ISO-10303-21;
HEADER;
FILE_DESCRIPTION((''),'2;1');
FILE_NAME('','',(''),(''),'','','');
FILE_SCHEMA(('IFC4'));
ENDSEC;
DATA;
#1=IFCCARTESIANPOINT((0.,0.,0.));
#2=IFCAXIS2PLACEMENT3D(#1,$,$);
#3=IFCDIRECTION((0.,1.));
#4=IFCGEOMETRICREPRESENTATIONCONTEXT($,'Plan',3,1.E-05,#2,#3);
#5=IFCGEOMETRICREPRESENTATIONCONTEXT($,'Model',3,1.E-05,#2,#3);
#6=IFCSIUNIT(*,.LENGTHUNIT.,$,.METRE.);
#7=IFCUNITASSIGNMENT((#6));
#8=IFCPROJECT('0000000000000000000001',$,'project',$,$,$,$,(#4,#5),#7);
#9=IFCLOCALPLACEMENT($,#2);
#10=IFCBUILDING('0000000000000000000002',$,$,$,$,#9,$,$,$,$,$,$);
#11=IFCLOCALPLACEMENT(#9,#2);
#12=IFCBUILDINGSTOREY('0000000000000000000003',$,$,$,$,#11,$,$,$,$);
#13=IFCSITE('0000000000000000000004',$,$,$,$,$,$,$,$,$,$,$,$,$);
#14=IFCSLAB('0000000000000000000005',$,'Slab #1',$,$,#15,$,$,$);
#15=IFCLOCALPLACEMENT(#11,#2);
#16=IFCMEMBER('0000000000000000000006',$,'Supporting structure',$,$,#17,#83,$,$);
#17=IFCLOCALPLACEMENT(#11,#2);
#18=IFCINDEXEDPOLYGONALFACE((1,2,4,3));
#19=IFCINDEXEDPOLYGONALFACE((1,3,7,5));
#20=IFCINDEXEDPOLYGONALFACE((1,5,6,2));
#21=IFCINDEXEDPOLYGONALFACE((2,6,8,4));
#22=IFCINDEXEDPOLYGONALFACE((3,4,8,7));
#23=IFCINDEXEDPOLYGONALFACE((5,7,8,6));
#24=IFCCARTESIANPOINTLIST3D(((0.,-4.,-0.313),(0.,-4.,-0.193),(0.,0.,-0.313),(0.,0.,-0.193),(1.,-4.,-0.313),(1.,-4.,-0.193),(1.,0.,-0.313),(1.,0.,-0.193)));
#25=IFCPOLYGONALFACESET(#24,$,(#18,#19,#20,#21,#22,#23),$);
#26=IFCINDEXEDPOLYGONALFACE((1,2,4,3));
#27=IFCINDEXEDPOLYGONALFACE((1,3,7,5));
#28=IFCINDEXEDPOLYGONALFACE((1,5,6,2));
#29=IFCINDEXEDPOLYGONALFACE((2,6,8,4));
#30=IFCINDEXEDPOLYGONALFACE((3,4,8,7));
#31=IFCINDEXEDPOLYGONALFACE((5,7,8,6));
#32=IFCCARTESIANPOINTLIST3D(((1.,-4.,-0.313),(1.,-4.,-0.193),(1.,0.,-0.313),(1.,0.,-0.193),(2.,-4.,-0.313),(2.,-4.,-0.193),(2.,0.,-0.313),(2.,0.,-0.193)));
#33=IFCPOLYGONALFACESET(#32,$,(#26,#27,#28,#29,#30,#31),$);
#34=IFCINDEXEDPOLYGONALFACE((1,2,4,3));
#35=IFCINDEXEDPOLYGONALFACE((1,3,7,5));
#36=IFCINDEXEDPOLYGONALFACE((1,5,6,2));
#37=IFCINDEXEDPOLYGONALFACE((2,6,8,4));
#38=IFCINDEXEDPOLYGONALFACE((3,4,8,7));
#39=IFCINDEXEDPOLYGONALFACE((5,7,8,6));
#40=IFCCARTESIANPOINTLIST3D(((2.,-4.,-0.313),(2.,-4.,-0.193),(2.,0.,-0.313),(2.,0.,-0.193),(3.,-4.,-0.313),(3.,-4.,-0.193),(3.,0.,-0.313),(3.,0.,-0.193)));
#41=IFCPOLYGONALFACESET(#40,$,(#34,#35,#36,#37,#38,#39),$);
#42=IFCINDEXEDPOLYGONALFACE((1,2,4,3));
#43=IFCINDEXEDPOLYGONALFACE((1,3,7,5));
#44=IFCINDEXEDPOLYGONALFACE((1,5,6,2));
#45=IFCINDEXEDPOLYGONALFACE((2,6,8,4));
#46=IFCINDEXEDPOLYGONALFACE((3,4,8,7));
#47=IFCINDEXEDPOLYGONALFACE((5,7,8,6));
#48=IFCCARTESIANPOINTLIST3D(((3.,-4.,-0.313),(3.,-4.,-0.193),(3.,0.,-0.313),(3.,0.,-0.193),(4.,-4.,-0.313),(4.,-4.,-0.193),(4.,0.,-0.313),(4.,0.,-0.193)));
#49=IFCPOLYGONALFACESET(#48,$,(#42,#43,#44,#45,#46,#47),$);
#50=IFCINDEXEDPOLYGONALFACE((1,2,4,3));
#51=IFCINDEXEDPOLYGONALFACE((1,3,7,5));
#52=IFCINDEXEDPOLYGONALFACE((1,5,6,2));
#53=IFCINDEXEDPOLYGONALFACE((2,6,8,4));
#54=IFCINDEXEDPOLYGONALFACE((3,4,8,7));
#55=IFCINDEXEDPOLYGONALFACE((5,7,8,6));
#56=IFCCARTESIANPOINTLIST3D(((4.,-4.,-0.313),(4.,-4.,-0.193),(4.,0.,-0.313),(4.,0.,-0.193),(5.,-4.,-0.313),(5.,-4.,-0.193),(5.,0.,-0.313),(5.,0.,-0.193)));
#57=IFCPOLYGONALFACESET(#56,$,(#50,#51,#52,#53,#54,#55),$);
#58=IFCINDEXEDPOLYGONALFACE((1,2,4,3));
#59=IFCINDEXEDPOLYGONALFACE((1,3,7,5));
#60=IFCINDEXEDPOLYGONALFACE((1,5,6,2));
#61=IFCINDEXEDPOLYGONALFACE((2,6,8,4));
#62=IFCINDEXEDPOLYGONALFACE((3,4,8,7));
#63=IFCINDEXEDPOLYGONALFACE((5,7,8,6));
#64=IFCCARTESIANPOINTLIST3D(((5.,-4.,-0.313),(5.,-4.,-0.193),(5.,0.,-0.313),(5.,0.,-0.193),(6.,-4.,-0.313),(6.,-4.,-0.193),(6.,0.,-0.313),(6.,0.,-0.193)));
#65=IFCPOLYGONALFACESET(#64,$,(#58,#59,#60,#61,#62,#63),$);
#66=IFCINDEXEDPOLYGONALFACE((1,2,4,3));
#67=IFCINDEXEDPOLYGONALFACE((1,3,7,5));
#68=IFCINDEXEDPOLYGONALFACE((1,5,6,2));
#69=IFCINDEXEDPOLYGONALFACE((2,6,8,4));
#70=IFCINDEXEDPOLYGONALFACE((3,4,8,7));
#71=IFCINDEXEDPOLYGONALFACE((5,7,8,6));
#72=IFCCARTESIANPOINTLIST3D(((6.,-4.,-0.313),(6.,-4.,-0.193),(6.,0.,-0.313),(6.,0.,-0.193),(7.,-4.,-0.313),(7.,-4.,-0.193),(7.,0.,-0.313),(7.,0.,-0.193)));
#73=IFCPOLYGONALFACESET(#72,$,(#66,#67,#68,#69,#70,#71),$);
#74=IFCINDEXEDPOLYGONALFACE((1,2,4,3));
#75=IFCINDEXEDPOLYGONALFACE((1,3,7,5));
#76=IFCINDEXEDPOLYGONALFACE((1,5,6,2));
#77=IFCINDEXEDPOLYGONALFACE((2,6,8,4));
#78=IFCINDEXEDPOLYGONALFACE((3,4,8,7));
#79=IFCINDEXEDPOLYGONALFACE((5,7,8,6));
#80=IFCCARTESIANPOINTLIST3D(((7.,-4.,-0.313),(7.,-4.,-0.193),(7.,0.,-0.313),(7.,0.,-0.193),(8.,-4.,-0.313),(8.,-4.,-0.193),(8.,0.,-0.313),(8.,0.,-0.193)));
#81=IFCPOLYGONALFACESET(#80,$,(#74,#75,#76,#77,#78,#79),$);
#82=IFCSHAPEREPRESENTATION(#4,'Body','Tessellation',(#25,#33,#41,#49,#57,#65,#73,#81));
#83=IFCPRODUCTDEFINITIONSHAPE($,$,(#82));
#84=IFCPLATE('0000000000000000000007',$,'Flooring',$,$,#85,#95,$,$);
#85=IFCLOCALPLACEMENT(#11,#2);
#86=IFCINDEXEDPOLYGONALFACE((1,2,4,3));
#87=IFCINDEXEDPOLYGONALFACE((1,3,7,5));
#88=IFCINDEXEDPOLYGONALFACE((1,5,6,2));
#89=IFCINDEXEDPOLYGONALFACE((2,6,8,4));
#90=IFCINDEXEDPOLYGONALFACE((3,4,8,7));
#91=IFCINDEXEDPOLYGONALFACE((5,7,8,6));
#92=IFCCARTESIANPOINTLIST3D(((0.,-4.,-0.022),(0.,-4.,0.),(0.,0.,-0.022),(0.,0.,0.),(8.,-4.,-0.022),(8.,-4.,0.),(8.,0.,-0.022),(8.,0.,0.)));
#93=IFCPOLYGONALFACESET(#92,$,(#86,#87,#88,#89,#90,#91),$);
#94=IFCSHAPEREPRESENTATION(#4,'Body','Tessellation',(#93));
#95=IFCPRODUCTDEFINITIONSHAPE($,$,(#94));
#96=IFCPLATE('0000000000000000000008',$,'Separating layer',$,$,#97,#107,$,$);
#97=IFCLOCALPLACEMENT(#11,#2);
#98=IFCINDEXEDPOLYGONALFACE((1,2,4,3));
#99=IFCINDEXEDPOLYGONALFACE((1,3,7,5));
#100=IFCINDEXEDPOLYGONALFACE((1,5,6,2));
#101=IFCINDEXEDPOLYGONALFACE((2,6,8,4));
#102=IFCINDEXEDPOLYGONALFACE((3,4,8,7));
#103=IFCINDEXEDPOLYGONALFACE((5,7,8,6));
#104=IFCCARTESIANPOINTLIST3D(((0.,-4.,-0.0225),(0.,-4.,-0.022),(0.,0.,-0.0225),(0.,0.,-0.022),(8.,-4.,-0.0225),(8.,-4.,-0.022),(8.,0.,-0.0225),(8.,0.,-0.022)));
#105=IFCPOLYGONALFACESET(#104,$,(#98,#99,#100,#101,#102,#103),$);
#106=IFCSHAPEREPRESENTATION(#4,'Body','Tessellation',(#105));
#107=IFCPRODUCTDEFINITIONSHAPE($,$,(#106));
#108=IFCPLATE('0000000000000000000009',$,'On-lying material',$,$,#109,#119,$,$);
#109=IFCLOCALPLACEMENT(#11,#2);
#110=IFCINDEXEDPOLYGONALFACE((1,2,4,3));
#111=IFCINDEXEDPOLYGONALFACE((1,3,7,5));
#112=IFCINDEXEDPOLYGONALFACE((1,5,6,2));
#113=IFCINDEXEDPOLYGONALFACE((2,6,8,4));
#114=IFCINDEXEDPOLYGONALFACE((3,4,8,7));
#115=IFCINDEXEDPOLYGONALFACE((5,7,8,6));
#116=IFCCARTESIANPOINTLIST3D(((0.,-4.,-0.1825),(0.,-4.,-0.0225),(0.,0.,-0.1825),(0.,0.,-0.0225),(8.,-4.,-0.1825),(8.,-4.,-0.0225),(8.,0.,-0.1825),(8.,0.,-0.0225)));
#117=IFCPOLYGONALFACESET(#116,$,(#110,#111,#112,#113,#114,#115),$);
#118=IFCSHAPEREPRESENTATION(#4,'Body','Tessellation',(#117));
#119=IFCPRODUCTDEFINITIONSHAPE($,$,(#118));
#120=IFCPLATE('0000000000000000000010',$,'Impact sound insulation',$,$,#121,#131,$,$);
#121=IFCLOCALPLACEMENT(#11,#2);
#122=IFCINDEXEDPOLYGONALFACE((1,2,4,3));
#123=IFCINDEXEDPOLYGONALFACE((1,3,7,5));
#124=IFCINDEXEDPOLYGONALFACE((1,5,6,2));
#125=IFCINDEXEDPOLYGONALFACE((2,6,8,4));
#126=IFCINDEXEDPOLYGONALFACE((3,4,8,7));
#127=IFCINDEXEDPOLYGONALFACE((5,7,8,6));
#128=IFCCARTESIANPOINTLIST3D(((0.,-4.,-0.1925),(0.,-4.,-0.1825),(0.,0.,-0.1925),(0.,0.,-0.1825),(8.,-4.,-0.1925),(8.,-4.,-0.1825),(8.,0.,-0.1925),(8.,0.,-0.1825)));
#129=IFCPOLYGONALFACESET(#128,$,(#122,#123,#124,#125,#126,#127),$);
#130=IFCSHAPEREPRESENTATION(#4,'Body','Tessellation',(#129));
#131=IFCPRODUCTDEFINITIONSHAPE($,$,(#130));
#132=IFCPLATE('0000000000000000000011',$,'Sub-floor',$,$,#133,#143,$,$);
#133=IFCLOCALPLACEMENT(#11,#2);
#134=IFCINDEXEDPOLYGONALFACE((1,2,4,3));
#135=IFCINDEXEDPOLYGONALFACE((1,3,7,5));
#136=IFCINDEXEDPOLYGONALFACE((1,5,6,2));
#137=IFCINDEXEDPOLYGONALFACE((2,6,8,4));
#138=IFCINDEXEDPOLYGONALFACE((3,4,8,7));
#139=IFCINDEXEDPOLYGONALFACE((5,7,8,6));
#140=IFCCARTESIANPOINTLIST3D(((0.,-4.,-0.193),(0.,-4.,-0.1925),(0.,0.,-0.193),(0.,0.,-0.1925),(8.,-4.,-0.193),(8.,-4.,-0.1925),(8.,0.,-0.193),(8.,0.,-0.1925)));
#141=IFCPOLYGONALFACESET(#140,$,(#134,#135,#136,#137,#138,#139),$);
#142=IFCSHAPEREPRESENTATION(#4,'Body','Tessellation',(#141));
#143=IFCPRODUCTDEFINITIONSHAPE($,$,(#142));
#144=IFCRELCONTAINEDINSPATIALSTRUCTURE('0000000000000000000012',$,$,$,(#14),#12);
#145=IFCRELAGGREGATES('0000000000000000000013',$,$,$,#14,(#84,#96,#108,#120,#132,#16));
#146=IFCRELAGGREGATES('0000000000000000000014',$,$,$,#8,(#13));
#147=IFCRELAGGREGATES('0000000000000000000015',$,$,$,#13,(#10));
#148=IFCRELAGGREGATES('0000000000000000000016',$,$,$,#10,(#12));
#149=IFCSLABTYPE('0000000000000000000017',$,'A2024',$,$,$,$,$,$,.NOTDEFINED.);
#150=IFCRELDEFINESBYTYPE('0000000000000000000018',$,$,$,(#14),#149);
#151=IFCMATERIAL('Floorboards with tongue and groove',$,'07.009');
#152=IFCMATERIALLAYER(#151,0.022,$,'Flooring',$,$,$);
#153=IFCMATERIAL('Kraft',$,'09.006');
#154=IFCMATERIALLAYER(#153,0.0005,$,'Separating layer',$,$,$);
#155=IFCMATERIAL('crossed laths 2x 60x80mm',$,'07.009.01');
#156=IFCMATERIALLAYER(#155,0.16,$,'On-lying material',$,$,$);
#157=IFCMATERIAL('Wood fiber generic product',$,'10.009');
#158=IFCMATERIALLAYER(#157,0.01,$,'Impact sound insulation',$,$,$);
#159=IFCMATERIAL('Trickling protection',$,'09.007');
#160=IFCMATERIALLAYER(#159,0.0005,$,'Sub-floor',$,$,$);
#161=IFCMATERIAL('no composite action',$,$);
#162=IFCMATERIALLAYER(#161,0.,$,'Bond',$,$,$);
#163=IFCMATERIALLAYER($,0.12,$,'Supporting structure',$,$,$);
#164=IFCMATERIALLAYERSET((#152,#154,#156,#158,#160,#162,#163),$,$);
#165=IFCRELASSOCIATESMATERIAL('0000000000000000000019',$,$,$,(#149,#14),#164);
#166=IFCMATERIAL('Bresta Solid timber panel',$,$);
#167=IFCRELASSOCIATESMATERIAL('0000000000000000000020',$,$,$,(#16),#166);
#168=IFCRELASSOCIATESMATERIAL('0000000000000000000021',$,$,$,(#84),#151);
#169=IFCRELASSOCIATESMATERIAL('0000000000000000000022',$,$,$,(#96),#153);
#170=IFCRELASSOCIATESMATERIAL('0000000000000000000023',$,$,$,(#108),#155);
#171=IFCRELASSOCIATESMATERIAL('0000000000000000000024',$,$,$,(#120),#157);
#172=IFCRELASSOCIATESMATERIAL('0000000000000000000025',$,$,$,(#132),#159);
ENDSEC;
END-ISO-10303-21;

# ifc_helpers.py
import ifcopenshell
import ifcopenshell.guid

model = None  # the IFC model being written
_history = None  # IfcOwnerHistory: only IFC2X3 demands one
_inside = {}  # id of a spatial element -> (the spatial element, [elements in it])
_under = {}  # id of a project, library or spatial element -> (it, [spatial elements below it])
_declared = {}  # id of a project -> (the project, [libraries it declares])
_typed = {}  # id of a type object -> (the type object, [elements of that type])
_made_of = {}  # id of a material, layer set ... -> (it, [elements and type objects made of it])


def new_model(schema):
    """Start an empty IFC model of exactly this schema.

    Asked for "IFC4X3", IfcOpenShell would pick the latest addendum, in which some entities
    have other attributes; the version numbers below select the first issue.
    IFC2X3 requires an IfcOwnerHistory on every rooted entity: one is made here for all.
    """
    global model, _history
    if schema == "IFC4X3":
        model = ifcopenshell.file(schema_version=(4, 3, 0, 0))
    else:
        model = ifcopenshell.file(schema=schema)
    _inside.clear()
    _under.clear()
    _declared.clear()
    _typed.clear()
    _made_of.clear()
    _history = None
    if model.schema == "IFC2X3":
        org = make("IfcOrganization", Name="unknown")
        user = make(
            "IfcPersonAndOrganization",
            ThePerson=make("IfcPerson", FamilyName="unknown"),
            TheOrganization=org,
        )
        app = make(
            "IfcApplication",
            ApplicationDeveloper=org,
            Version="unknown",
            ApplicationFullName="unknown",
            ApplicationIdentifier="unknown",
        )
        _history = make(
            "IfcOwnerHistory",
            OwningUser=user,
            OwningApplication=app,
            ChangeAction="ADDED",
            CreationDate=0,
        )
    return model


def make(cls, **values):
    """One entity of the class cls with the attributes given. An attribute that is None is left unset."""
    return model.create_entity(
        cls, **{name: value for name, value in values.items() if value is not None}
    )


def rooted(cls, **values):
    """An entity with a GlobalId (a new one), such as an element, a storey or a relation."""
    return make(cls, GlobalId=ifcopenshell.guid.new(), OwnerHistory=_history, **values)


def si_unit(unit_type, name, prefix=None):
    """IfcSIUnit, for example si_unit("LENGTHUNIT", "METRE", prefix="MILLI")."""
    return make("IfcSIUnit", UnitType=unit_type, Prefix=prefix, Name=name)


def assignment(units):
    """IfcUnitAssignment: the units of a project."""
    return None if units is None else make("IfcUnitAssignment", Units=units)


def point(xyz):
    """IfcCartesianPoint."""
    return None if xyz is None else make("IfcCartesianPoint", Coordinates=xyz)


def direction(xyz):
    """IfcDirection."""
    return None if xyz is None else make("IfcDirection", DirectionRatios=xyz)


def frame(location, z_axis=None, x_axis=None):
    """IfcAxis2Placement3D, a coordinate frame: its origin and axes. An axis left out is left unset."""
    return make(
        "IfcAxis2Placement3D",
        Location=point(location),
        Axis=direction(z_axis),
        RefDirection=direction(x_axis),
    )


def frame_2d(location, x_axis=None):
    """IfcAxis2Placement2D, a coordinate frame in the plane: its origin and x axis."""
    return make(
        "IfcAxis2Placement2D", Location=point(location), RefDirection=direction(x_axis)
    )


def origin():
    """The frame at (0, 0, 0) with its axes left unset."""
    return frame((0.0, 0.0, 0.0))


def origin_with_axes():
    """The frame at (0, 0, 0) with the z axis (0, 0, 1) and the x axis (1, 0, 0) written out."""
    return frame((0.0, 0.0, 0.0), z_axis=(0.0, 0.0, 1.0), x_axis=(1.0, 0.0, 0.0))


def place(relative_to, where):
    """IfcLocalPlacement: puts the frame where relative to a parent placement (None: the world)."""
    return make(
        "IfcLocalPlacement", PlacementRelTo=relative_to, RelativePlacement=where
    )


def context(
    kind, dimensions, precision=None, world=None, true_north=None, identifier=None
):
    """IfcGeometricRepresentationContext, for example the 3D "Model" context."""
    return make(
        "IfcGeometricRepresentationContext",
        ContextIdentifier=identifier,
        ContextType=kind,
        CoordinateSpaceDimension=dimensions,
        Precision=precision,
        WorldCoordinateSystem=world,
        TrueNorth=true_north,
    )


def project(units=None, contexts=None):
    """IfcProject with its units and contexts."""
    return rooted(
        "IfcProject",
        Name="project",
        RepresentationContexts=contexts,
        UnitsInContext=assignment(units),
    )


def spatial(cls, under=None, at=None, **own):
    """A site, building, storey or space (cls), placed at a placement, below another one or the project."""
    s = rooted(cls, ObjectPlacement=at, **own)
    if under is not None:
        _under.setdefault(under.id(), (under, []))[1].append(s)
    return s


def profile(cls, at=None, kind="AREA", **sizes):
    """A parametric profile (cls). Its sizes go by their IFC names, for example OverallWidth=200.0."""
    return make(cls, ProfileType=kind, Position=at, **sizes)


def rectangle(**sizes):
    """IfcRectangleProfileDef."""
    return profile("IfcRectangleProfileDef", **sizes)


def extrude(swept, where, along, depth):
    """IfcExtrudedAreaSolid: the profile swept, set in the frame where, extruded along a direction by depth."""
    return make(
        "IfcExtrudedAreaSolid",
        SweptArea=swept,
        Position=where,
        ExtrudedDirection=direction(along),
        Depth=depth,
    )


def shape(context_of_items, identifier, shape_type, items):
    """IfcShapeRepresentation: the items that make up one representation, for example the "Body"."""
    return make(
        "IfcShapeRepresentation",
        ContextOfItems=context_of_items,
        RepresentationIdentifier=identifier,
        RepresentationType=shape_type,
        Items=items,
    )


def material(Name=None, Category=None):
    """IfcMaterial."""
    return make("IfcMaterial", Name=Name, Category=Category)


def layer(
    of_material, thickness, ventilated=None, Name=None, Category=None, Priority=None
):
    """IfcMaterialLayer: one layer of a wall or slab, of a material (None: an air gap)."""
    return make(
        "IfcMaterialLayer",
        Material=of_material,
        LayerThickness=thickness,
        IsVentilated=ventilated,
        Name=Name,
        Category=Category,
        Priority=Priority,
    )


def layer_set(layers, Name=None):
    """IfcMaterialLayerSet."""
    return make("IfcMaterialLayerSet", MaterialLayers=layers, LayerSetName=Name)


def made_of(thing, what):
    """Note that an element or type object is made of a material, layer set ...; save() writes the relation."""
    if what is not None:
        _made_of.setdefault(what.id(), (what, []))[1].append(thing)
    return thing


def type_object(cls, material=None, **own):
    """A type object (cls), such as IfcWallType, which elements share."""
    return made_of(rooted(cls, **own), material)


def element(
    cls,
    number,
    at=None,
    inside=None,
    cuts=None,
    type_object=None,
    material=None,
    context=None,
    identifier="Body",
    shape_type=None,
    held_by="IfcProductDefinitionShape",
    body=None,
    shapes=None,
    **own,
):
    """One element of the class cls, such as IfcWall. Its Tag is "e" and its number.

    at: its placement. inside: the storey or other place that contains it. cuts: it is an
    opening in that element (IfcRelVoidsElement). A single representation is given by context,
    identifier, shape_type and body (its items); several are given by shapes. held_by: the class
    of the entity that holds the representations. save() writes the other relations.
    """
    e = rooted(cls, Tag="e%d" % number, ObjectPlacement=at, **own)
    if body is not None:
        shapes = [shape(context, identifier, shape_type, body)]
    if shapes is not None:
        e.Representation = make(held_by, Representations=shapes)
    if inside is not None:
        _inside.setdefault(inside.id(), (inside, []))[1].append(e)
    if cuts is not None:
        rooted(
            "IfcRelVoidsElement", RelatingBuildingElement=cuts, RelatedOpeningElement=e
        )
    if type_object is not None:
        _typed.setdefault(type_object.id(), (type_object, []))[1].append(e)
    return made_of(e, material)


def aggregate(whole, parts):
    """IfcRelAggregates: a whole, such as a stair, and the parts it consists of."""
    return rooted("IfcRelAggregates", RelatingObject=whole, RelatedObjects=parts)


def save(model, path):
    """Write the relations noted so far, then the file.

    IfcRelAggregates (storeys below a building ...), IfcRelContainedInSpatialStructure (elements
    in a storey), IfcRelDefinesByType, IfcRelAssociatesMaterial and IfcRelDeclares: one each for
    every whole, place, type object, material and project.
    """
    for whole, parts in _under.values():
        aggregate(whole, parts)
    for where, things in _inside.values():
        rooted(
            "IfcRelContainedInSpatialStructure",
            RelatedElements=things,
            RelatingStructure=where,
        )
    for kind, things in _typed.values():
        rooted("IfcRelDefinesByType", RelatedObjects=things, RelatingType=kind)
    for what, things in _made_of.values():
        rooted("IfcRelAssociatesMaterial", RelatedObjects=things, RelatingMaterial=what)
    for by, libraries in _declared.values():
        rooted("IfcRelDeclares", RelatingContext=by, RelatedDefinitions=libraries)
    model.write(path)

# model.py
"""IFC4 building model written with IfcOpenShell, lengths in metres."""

from ifc_helpers import new_model, si_unit, direction, frame, frame_2d, origin, origin_with_axes, place, context, project, spatial, rectangle, extrude, material, layer, layer_set, type_object, element, aggregate, save


model = new_model("IFC4")

# Units and contexts
plan_context = context("Plan", 3, precision=1e-05, world=origin(), true_north=direction((0.0, 1.0)))
model_context = context("Model", 3, precision=1e-05, world=origin(), true_north=direction((0.0, 1.0)))
ifc_project = project(units=[si_unit("LENGTHUNIT", "METRE")], contexts=[plan_context, model_context])

# Site, building, storey
site = spatial("IfcSite", under=ifc_project)
building_placement = place(None, origin())
building = spatial("IfcBuilding", under=site, at=building_placement)
storey_placement = place(building_placement, origin())
storey = spatial("IfcBuildingStorey", under=building, at=storey_placement)

# Slab, member, plates
ifc_material_1 = material(Name="Floorboards with tongue and groove", Category="07.009")
ifc_layer_1 = layer(ifc_material_1, 0.022, Name="Flooring")
ifc_material_2 = material(Name="Kraft", Category="09.006")
ifc_layer_2 = layer(ifc_material_2, 0.0005, Name="Separating layer")
ifc_material_3 = material(Name="crossed laths 2x 60x80mm", Category="07.009.01")
ifc_layer_3 = layer(ifc_material_3, 0.16, Name="On-lying material")
ifc_material_4 = material(Name="Wood fiber generic product", Category="10.009")
ifc_layer_4 = layer(ifc_material_4, 0.01, Name="Impact sound insulation")
ifc_material_5 = material(Name="Trickling protection", Category="09.007")
ifc_layer_5 = layer(ifc_material_5, 0.0005, Name="Sub-floor")
ifc_material_6 = material(Name="no composite action")
ifc_layer_6 = layer(ifc_material_6, 0.0, Name="Bond")
ifc_layer_7 = layer(None, 0.12, Name="Supporting structure")
ifc_layer_set = layer_set([ifc_layer_1, ifc_layer_2, ifc_layer_3, ifc_layer_4, ifc_layer_5, ifc_layer_6, ifc_layer_7])
slab_type = type_object("IfcSlabType", Name="A2024", PredefinedType="NOTDEFINED", material=ifc_layer_set)
slab_placement = place(None, frame((0.0, 0.0, 0.0), z_axis=(0.0, 0.0, -1.0), x_axis=(1.0, 0.0, 0.0)))
slab = element("IfcSlab", 1, at=slab_placement, inside=storey, type_object=slab_type, material=ifc_layer_set, Name="Slab #1")
ifc_material_7 = material(Name="Bresta Solid timber panel")
member_placement = place(slab_placement, origin())
member = element("IfcMember", 2, at=member_placement, material=ifc_material_7, Name="Supporting structure", context=plan_context, shape_type="SweptSolid", body=[
    extrude(rectangle(XDim=1.0, YDim=0.12, at=frame_2d((0.5, 0.06), x_axis=(1.0, 0.0))), frame((0.0, 4.0, 0.193), z_axis=(0.0, -1.0, 0.0), x_axis=(1.0, 0.0, 0.0)), (0.0, 0.0, 1.0), 4.0),
    extrude(rectangle(XDim=1.0, YDim=0.12, at=frame_2d((0.5, 0.06), x_axis=(1.0, 0.0))), frame((1.0, 4.0, 0.193), z_axis=(0.0, -1.0, 0.0), x_axis=(1.0, 0.0, 0.0)), (0.0, 0.0, 1.0), 4.0),
    extrude(rectangle(XDim=1.0, YDim=0.12, at=frame_2d((0.5, 0.06), x_axis=(1.0, 0.0))), frame((2.0, 4.0, 0.193), z_axis=(0.0, -1.0, 0.0), x_axis=(1.0, 0.0, 0.0)), (0.0, 0.0, 1.0), 4.0),
    extrude(rectangle(XDim=1.0, YDim=0.12, at=frame_2d((0.5, 0.06), x_axis=(1.0, 0.0))), frame((3.0, 4.0, 0.193), z_axis=(0.0, -1.0, 0.0), x_axis=(1.0, 0.0, 0.0)), (0.0, 0.0, 1.0), 4.0),
    extrude(rectangle(XDim=1.0, YDim=0.12, at=frame_2d((0.5, 0.06), x_axis=(1.0, 0.0))), frame((4.0, 4.0, 0.193), z_axis=(0.0, -1.0, 0.0), x_axis=(1.0, 0.0, 0.0)), (0.0, 0.0, 1.0), 4.0),
    extrude(rectangle(XDim=1.0, YDim=0.12, at=frame_2d((0.5, 0.06), x_axis=(1.0, 0.0))), frame((5.0, 4.0, 0.193), z_axis=(0.0, -1.0, 0.0), x_axis=(1.0, 0.0, 0.0)), (0.0, 0.0, 1.0), 4.0),
    extrude(rectangle(XDim=1.0, YDim=0.12, at=frame_2d((0.5, 0.06), x_axis=(1.0, 0.0))), frame((6.0, 4.0, 0.193), z_axis=(0.0, -1.0, 0.0), x_axis=(1.0, 0.0, 0.0)), (0.0, 0.0, 1.0), 4.0),
    extrude(rectangle(XDim=1.0, YDim=0.12, at=frame_2d((0.5, 0.06), x_axis=(1.0, 0.0))), frame((7.0, 4.0, 0.193), z_axis=(0.0, -1.0, 0.0), x_axis=(1.0, 0.0, 0.0)), (0.0, 0.0, 1.0), 4.0),
])
plate_1_placement = place(slab_placement, origin())
plate_1 = element("IfcPlate", 3, at=plate_1_placement, material=ifc_material_1, Name="Flooring", context=plan_context, shape_type="SweptSolid", body=[
    extrude(rectangle(XDim=8.0, YDim=4.0, at=frame_2d((4.0, 2.0), x_axis=(1.0, 0.0))), origin_with_axes(), (0.0, 0.0, 1.0), 0.022),
])
plate_2_placement = place(slab_placement, origin())
plate_2 = element("IfcPlate", 4, at=plate_2_placement, material=ifc_material_2, Name="Separating layer", context=plan_context, shape_type="SweptSolid", body=[
    extrude(rectangle(XDim=8.0, YDim=4.0, at=frame_2d((4.0, 2.0), x_axis=(1.0, 0.0))), frame((0.0, 0.0, 0.022), z_axis=(0.0, 0.0, 1.0), x_axis=(1.0, 0.0, 0.0)), (0.0, 0.0, 1.0), 0.0005),
])
plate_3_placement = place(slab_placement, origin())
plate_3 = element("IfcPlate", 5, at=plate_3_placement, material=ifc_material_3, Name="On-lying material", context=plan_context, shape_type="SweptSolid", body=[
    extrude(rectangle(XDim=8.0, YDim=4.0, at=frame_2d((4.0, 2.0), x_axis=(1.0, 0.0))), frame((0.0, 0.0, 0.0225), z_axis=(0.0, 0.0, 1.0), x_axis=(1.0, 0.0, 0.0)), (0.0, 0.0, 1.0), 0.16),
])
plate_4_placement = place(slab_placement, origin())
plate_4 = element("IfcPlate", 6, at=plate_4_placement, material=ifc_material_4, Name="Impact sound insulation", context=plan_context, shape_type="SweptSolid", body=[
    extrude(rectangle(XDim=8.0, YDim=4.0, at=frame_2d((4.0, 2.0), x_axis=(1.0, 0.0))), frame((0.0, 0.0, 0.1825), z_axis=(0.0, 0.0, 1.0), x_axis=(1.0, 0.0, 0.0)), (0.0, 0.0, 1.0), 0.01),
])
plate_5_placement = place(slab_placement, origin())
plate_5 = element("IfcPlate", 7, at=plate_5_placement, material=ifc_material_5, Name="Sub-floor", context=plan_context, shape_type="SweptSolid", body=[
    extrude(rectangle(XDim=8.0, YDim=4.0, at=frame_2d((4.0, 2.0), x_axis=(1.0, 0.0))), frame((0.0, 0.0, 0.1925), z_axis=(0.0, 0.0, 1.0), x_axis=(1.0, 0.0, 0.0)), (0.0, 0.0, 1.0), 0.0005),
])
aggregate(slab, [plate_1, plate_2, plate_3, plate_4, plate_5, member])

save(model, "model.ifc")
